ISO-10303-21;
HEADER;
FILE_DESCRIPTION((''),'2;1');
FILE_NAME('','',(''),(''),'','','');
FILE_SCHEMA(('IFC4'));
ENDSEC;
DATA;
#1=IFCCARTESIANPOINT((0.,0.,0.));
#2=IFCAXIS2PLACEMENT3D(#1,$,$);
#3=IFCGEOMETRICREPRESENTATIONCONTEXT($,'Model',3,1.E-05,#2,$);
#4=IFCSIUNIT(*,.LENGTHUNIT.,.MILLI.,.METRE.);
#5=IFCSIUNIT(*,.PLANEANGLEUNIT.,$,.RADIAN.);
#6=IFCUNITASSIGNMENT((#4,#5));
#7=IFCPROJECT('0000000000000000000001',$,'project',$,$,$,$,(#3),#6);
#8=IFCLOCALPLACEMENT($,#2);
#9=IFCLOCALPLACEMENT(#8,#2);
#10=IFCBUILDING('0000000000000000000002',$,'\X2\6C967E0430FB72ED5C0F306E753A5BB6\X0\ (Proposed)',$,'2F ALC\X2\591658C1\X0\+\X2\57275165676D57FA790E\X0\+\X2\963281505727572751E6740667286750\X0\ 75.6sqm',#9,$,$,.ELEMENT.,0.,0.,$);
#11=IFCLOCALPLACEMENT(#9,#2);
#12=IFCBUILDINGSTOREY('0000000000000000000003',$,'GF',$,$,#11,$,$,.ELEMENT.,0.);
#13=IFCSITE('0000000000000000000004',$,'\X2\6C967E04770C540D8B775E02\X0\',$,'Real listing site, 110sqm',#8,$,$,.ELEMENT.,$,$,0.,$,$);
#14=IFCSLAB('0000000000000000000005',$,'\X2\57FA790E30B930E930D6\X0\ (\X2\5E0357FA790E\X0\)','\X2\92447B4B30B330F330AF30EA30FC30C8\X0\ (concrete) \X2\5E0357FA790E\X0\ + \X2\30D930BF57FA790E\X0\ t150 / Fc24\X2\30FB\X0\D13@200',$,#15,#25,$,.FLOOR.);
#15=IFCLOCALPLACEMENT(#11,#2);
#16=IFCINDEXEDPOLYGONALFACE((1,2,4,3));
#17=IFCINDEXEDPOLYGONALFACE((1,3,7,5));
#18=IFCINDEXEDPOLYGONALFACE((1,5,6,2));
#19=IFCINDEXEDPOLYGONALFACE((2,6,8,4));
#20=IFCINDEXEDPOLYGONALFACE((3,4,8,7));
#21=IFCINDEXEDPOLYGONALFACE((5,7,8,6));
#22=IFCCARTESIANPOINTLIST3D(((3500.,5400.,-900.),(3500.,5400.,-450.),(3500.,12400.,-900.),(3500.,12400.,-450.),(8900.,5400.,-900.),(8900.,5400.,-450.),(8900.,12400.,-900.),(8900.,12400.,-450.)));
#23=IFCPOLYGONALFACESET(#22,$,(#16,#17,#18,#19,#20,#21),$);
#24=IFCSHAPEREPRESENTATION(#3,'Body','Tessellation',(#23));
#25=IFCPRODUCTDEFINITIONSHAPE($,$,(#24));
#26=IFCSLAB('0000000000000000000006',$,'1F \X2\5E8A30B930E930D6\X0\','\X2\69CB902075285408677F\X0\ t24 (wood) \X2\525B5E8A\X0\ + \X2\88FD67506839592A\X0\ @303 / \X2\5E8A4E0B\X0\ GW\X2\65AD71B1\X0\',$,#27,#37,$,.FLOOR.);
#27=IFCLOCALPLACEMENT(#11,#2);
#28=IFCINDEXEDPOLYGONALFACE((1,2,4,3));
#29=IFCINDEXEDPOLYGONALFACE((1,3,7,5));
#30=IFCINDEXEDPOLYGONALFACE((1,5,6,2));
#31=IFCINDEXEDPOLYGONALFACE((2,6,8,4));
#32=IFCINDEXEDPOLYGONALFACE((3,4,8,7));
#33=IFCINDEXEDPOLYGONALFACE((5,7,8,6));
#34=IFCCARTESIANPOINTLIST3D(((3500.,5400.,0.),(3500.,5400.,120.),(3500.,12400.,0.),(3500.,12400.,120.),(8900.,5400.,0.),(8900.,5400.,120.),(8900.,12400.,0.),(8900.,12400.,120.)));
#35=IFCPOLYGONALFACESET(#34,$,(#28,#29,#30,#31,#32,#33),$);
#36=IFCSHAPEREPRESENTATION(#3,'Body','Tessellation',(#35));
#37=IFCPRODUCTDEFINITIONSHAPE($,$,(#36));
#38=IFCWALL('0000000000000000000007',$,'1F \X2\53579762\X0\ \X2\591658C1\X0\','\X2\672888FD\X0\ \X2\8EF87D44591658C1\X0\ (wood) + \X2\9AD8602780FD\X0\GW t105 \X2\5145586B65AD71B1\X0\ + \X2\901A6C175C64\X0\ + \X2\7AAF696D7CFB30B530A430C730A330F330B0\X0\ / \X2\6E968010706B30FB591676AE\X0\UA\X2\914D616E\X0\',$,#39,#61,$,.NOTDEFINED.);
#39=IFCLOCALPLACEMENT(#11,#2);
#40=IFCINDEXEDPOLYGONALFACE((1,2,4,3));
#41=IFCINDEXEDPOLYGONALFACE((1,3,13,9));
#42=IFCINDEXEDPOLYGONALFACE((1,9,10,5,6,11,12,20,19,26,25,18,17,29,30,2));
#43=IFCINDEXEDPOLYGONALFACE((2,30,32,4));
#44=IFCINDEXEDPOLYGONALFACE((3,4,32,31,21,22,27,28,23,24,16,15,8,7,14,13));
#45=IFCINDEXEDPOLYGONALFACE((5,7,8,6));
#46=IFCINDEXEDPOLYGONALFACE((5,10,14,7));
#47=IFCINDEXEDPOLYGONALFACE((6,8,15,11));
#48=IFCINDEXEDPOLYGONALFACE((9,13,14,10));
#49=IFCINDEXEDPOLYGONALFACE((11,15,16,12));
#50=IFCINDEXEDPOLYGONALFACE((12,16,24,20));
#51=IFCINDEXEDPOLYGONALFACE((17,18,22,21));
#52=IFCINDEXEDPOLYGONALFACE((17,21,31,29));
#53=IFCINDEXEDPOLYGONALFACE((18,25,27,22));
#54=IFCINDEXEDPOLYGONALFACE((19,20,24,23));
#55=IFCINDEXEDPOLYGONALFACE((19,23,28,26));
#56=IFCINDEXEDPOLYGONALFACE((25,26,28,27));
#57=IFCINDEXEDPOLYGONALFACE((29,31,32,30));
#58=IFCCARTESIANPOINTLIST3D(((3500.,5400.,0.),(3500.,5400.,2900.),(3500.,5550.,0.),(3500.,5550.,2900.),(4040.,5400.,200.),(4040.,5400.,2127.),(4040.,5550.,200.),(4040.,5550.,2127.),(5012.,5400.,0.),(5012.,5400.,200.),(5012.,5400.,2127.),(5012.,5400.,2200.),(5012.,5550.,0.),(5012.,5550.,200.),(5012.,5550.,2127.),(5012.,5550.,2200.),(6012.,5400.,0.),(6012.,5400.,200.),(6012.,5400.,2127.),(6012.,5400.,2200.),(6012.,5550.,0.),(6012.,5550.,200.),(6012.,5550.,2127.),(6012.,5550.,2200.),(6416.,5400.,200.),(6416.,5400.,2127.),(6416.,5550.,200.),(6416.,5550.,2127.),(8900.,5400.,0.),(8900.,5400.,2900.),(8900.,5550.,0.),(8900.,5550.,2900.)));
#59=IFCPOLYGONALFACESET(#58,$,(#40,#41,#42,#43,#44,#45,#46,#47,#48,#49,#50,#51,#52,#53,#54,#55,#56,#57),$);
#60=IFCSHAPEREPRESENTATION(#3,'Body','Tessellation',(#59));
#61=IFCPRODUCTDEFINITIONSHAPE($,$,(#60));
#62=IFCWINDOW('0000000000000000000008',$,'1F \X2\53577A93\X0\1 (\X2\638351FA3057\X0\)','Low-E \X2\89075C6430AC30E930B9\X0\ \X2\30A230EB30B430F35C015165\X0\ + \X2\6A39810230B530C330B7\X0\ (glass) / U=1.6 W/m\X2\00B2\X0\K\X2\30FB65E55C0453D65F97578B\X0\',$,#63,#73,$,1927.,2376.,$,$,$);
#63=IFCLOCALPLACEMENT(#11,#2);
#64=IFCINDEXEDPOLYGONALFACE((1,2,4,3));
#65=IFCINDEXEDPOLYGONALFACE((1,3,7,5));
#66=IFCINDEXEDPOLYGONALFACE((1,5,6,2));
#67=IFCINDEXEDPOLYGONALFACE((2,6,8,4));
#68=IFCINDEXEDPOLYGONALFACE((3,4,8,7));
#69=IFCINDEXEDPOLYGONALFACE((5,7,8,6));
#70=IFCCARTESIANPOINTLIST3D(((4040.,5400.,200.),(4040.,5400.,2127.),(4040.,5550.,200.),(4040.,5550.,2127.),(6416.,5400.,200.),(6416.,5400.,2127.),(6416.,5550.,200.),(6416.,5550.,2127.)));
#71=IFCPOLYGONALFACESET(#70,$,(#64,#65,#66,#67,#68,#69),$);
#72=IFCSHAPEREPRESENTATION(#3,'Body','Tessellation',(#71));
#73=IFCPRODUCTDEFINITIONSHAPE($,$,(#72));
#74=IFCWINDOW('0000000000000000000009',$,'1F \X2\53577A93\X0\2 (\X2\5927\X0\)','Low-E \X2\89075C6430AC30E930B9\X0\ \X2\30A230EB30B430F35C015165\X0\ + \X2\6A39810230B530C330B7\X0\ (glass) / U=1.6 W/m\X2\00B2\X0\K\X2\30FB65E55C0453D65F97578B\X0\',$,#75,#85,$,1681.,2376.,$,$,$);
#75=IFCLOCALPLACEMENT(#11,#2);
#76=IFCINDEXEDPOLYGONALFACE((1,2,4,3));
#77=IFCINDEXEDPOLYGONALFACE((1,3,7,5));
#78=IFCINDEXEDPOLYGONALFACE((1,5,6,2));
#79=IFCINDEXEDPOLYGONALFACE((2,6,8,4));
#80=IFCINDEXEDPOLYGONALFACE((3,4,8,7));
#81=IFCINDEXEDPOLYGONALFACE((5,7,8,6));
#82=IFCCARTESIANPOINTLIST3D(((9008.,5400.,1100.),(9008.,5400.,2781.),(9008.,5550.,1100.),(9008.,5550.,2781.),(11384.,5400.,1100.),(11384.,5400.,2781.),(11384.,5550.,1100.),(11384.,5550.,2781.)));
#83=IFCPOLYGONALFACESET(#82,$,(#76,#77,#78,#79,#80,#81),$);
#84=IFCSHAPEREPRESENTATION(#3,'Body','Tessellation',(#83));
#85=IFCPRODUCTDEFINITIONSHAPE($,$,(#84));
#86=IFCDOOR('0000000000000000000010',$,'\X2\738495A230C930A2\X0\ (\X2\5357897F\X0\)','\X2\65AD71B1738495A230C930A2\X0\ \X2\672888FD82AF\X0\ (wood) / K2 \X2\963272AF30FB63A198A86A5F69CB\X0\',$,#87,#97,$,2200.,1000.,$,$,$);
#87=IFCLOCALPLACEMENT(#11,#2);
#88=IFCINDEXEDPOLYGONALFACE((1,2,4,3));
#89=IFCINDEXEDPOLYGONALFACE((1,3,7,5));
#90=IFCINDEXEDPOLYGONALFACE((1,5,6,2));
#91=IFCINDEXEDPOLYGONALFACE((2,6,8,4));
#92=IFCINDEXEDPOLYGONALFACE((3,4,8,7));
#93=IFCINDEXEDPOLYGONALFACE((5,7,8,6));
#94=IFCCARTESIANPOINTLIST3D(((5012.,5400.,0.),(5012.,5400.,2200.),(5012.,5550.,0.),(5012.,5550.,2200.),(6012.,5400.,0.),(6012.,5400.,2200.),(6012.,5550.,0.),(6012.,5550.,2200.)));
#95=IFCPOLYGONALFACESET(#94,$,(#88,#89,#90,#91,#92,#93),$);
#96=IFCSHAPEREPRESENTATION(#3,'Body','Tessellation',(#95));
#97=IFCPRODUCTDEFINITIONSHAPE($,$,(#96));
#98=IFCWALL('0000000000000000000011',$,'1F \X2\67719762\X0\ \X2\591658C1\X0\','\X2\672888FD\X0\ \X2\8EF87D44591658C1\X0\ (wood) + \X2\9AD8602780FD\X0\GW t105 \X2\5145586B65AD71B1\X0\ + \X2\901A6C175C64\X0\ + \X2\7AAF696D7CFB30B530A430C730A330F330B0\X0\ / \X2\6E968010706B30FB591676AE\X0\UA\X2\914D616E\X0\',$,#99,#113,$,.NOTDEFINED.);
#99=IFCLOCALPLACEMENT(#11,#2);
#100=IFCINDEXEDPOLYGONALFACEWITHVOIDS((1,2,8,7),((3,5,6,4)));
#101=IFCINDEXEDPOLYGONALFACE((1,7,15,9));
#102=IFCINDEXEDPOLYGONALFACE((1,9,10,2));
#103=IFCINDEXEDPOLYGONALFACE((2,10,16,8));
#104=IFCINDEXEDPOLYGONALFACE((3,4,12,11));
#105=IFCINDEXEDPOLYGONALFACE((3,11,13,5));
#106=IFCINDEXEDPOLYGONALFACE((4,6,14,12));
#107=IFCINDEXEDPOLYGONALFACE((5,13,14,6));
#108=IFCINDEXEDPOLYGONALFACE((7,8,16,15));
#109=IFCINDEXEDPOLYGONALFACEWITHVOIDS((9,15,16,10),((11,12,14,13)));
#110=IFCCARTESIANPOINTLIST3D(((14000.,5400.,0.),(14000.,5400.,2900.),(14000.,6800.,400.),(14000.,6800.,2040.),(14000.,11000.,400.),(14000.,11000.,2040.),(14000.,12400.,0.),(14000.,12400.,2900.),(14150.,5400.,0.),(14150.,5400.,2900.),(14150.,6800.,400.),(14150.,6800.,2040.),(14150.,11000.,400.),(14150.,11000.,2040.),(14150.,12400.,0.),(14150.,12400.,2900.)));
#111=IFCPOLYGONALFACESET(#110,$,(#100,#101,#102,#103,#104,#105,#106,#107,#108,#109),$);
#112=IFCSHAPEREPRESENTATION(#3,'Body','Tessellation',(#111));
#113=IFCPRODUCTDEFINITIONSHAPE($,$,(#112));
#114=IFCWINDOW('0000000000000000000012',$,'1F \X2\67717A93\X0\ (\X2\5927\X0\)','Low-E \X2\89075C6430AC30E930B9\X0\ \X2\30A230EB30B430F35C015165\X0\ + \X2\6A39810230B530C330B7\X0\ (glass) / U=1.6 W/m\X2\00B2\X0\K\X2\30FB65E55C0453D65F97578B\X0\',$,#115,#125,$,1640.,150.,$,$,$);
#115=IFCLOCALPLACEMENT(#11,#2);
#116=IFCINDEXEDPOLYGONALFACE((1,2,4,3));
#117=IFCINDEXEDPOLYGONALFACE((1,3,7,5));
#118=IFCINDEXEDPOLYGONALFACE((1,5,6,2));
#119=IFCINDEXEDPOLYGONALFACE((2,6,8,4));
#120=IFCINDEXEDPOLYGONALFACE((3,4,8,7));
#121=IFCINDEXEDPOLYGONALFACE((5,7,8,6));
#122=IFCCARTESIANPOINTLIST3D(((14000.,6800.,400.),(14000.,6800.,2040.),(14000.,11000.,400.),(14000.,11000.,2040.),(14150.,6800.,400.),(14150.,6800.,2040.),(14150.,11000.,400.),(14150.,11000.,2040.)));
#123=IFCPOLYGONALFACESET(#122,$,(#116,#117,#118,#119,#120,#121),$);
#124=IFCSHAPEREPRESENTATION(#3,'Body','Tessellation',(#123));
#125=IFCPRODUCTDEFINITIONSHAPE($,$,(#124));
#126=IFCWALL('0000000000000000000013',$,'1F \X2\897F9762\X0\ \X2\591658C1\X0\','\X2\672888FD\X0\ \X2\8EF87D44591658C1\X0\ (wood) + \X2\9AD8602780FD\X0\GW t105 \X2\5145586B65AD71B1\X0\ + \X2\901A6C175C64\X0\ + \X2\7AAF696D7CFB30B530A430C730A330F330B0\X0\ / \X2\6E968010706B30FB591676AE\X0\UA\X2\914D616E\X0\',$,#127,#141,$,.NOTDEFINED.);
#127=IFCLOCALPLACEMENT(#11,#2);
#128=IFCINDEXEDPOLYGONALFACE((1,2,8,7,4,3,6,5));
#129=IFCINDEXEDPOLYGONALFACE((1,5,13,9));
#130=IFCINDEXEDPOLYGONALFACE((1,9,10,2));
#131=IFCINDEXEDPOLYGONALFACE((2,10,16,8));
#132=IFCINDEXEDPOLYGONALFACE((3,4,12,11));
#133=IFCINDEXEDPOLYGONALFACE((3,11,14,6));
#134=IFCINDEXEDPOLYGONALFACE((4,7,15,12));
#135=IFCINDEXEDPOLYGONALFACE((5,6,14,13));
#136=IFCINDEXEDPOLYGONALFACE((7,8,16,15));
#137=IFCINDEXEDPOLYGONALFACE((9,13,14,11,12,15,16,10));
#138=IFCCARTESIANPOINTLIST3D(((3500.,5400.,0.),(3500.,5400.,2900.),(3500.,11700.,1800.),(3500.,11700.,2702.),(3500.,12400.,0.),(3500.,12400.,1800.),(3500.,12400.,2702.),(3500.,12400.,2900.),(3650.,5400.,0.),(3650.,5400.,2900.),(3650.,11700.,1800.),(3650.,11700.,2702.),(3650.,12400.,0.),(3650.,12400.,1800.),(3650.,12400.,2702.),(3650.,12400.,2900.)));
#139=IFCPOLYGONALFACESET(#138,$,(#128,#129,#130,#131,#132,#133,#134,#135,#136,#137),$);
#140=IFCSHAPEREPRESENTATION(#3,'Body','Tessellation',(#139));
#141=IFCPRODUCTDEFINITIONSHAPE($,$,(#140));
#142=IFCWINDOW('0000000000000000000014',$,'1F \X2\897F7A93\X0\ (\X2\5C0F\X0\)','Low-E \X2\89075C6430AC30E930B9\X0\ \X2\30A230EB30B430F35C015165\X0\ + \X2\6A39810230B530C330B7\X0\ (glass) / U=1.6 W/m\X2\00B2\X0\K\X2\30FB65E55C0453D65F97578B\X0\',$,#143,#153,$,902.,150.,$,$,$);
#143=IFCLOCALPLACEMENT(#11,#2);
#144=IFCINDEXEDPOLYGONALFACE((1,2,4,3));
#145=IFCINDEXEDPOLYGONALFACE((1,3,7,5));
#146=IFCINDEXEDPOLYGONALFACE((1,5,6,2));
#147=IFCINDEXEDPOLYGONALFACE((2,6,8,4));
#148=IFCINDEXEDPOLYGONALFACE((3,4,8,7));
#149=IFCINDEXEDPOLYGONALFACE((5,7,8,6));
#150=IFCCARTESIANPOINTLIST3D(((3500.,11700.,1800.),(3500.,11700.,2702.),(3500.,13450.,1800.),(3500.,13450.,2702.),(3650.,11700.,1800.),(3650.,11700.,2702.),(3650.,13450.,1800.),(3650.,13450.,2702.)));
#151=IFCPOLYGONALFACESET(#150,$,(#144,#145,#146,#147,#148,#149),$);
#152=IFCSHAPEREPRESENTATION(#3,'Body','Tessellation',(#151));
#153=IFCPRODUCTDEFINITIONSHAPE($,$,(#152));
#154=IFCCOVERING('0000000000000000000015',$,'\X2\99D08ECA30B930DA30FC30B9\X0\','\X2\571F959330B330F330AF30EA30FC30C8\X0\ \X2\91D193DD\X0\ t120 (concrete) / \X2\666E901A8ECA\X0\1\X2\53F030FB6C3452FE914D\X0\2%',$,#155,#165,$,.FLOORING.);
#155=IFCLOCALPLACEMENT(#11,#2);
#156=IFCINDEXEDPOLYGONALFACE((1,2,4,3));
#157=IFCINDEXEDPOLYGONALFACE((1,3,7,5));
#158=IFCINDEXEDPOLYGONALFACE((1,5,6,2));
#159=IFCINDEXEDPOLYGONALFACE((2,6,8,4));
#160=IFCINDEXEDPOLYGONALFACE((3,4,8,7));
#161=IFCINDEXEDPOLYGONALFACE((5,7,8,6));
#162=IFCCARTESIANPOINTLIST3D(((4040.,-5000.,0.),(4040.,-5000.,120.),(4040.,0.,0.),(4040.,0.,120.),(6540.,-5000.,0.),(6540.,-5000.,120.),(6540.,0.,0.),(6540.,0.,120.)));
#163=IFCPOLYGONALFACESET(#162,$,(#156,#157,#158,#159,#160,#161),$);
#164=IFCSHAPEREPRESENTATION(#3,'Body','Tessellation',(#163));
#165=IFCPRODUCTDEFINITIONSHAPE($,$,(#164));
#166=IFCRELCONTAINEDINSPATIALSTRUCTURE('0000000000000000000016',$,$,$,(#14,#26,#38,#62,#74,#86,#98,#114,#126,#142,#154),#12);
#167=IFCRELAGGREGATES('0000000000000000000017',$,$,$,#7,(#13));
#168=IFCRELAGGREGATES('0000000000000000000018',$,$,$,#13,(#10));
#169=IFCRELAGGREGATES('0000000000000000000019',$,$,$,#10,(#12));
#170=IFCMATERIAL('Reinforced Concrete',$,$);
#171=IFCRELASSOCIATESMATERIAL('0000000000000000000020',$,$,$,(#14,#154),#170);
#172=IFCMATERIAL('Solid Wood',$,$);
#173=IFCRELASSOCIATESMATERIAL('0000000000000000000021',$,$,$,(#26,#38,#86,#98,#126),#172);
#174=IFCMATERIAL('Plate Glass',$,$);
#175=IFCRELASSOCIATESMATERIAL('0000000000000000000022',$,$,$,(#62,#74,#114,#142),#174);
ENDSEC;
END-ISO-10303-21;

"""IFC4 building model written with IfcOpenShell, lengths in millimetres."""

from ifc_helpers import new_model, si_unit, frame, frame_2d, origin, place, context, project, spatial, rectangle, extrude, material, element, fill, save


model = new_model("IFC4")

# Units and contexts
model_context = context("Model", 3, precision=1e-05, world=origin())
ifc_project = project(units=[si_unit("LENGTHUNIT", "METRE", prefix="MILLI"), si_unit("PLANEANGLEUNIT", "RADIAN")], contexts=[model_context])

# Site, building, storey
site_placement = place(None, origin())
site = spatial("IfcSite", under=ifc_project, at=site_placement, Name="沖縄県名護市", ObjectType="Real listing site, 110sqm", CompositionType="ELEMENT", RefElevation=0.0)
building_placement = place(site_placement, origin())
building = spatial("IfcBuilding", under=site, at=building_placement, Name="沖縄・狭小の町家 (Proposed)", ObjectType="2F ALC外壁+圧入杭基礎+防腐圧圧処理木材 75.6sqm", CompositionType="ELEMENT", ElevationOfRefHeight=0.0, ElevationOfTerrain=0.0)
storey_placement = place(building_placement, origin())
storey = spatial("IfcBuildingStorey", under=building, at=storey_placement, Name="GF", CompositionType="ELEMENT", Elevation=0.0)

# Shared definitions
ifc_material_1 = material(Name="Solid Wood")

# Slabs
ifc_material_2 = material(Name="Reinforced Concrete")
slab_1_placement = place(storey_placement, frame((1750.0, 2700.0, -450.0)))
element("IfcSlab", 1, at=slab_1_placement, inside=storey, material=ifc_material_2, Name="基礎スラブ (布基礎)", Description="鉄筋コンクリート (concrete) 布基礎 + ベタ基礎 t150 / Fc24・D13@200", PredefinedType="FLOOR", context=model_context, shape_type="SweptSolid", body=[
    extrude(rectangle(XDim=5400.0, YDim=7000.0, at=frame_2d((2700.0, 3500.0))), frame((1750.0, 2700.0, -450.0)), (0.0, 0.0, 1.0), 450.0),
])
slab_2_placement = place(storey_placement, frame((1750.0, 2700.0, 0.0)))
element("IfcSlab", 2, at=slab_2_placement, inside=storey, material=ifc_material_1, Name="1F 床スラブ", Description="構造用合板 t24 (wood) 剛床 + 製材根太 @303 / 床下 GW断熱", PredefinedType="FLOOR", context=model_context, shape_type="SweptSolid", body=[
    extrude(rectangle(XDim=5400.0, YDim=7000.0, at=frame_2d((2700.0, 3500.0))), frame((1750.0, 2700.0, 0.0)), (0.0, 0.0, 1.0), 120.0),
])

# Wall, openings, windows, door
wall_1_placement = place(storey_placement, frame((1750.0, 2700.0, 0.0)))
wall_1 = element("IfcWall", 3, at=wall_1_placement, inside=storey, material=ifc_material_1, Name="1F 南面 外壁", Description="木製 軸組外壁 (wood) + 高性能GW t105 充填断熱 + 通気層 + 窯業系サイディング / 準耐火・外皮UA配慮", PredefinedType="NOTDEFINED", context=model_context, shape_type="SweptSolid", body=[
    extrude(rectangle(XDim=5400.0, YDim=150.0, at=frame_2d((2700.0, 75.0))), frame((1750.0, 2700.0, 0.0)), (0.0, 0.0, 1.0), 2900.0),
])
opening_1_placement = place(storey_placement, frame((2020.0, 2700.0, 100.0)))
opening_1 = element("IfcOpeningElement", 4, at=opening_1_placement, cuts=wall_1, PredefinedType="NOTDEFINED", context=model_context, shape_type="SweptSolid", body=[
    extrude(rectangle(XDim=2376.0, YDim=150.0, at=frame_2d((1188.0, 75.0))), frame((2020.0, 2700.0, 100.0)), (0.0, 0.0, 1.0), 1927.0),
])
opening_2_placement = place(storey_placement, frame((4504.0, 2700.0, 550.0)))
opening_2 = element("IfcOpeningElement", 5, at=opening_2_placement, cuts=wall_1, PredefinedType="NOTDEFINED", context=model_context, shape_type="SweptSolid", body=[
    extrude(rectangle(XDim=2376.0, YDim=150.0, at=frame_2d((1188.0, 75.0))), frame((4504.0, 2700.0, 550.0)), (0.0, 0.0, 1.0), 1681.0),
])
opening_3_placement = place(storey_placement, frame((2506.0, 2700.0, 0.0)))
opening_3 = element("IfcOpeningElement", 6, at=opening_3_placement, cuts=wall_1, PredefinedType="NOTDEFINED", context=model_context, shape_type="SweptSolid", body=[
    extrude(rectangle(XDim=1000.0, YDim=150.0, at=frame_2d((500.0, 75.0))), frame((2506.0, 2700.0, 0.0)), (0.0, 0.0, 1.0), 2200.0),
])
ifc_material_3 = material(Name="Plate Glass")
window_1_placement = place(storey_placement, frame((2020.0, 2700.0, 100.0)))
window_1 = element("IfcWindow", 7, at=window_1_placement, inside=storey, material=ifc_material_3, Name="1F 南窓1 (掃出し)", Description="Low-E 複層ガラス アルゴン封入 + 樹脂サッシ (glass) / U=1.6 W/m²K・日射取得型", OverallHeight=1927.0, OverallWidth=2376.0, context=model_context, shape_type="SweptSolid", body=[
    extrude(rectangle(XDim=2376.0, YDim=150.0, at=frame_2d((1188.0, 75.0))), frame((2020.0, 2700.0, 100.0)), (0.0, 0.0, 1.0), 1927.0),
])
fill(opening_1, window_1)
window_2_placement = place(storey_placement, frame((4504.0, 2700.0, 550.0)))
window_2 = element("IfcWindow", 8, at=window_2_placement, inside=storey, material=ifc_material_3, Name="1F 南窓2 (大)", Description="Low-E 複層ガラス アルゴン封入 + 樹脂サッシ (glass) / U=1.6 W/m²K・日射取得型", OverallHeight=1681.0, OverallWidth=2376.0, context=model_context, shape_type="SweptSolid", body=[
    extrude(rectangle(XDim=2376.0, YDim=150.0, at=frame_2d((1188.0, 75.0))), frame((4504.0, 2700.0, 550.0)), (0.0, 0.0, 1.0), 1681.0),
])
fill(opening_2, window_2)
door_placement = place(storey_placement, frame((2506.0, 2700.0, 0.0)))
door = element("IfcDoor", 9, at=door_placement, inside=storey, material=ifc_material_1, Name="玄関ドア (南西)", Description="断熱玄関ドア 木製芯 (wood) / K2 防犯・採風機構", OverallHeight=2200.0, OverallWidth=1000.0, context=model_context, shape_type="SweptSolid", body=[
    extrude(rectangle(XDim=1000.0, YDim=150.0, at=frame_2d((500.0, 75.0))), frame((2506.0, 2700.0, 0.0)), (0.0, 0.0, 1.0), 2200.0),
])
fill(opening_3, door)

# Walls, openings, windows
wall_2_placement = place(storey_placement, frame((7000.0, 2700.0, 0.0)))
wall_2 = element("IfcWall", 10, at=wall_2_placement, inside=storey, material=ifc_material_1, Name="1F 東面 外壁", Description="木製 軸組外壁 (wood) + 高性能GW t105 充填断熱 + 通気層 + 窯業系サイディング / 準耐火・外皮UA配慮", PredefinedType="NOTDEFINED", context=model_context, shape_type="SweptSolid", body=[
    extrude(rectangle(XDim=150.0, YDim=7000.0, at=frame_2d((75.0, 3500.0))), frame((7000.0, 2700.0, 0.0)), (0.0, 0.0, 1.0), 2900.0),
])
opening_4_placement = place(storey_placement, frame((7000.0, 3400.0, 200.0)))
opening_4 = element("IfcOpeningElement", 11, at=opening_4_placement, cuts=wall_2, PredefinedType="NOTDEFINED", context=model_context, shape_type="SweptSolid", body=[
    extrude(rectangle(XDim=150.0, YDim=4200.0, at=frame_2d((75.0, 2100.0))), frame((7000.0, 3400.0, 200.0)), (0.0, 0.0, 1.0), 1640.0),
])
window_3_placement = place(storey_placement, frame((7000.0, 3400.0, 200.0)))
window_3 = element("IfcWindow", 12, at=window_3_placement, inside=storey, material=ifc_material_3, Name="1F 東窓 (大)", Description="Low-E 複層ガラス アルゴン封入 + 樹脂サッシ (glass) / U=1.6 W/m²K・日射取得型", OverallHeight=1640.0, OverallWidth=150.0, context=model_context, shape_type="SweptSolid", body=[
    extrude(rectangle(XDim=150.0, YDim=4200.0, at=frame_2d((75.0, 2100.0))), frame((7000.0, 3400.0, 200.0)), (0.0, 0.0, 1.0), 1640.0),
])
fill(opening_4, window_3)
wall_3_placement = place(storey_placement, frame((1750.0, 2700.0, 0.0)))
wall_3 = element("IfcWall", 13, at=wall_3_placement, inside=storey, material=ifc_material_1, Name="1F 西面 外壁", Description="木製 軸組外壁 (wood) + 高性能GW t105 充填断熱 + 通気層 + 窯業系サイディング / 準耐火・外皮UA配慮", PredefinedType="NOTDEFINED", context=model_context, shape_type="SweptSolid", body=[
    extrude(rectangle(XDim=150.0, YDim=7000.0, at=frame_2d((75.0, 3500.0))), frame((1750.0, 2700.0, 0.0)), (0.0, 0.0, 1.0), 2900.0),
])
opening_5_placement = place(storey_placement, frame((1750.0, 5850.0, 900.0)))
opening_5 = element("IfcOpeningElement", 14, at=opening_5_placement, cuts=wall_3, PredefinedType="NOTDEFINED", context=model_context, shape_type="SweptSolid", body=[
    extrude(rectangle(XDim=150.0, YDim=1750.0, at=frame_2d((75.0, 875.0))), frame((1750.0, 5850.0, 900.0)), (0.0, 0.0, 1.0), 902.0),
])
window_4_placement = place(storey_placement, frame((1750.0, 5850.0, 900.0)))
window_4 = element("IfcWindow", 15, at=window_4_placement, inside=storey, material=ifc_material_3, Name="1F 西窓 (小)", Description="Low-E 複層ガラス アルゴン封入 + 樹脂サッシ (glass) / U=1.6 W/m²K・日射取得型", OverallHeight=902.0, OverallWidth=150.0, context=model_context, shape_type="SweptSolid", body=[
    extrude(rectangle(XDim=150.0, YDim=1750.0, at=frame_2d((75.0, 875.0))), frame((1750.0, 5850.0, 900.0)), (0.0, 0.0, 1.0), 902.0),
])
fill(opening_5, window_4)

# Covering
covering_1_placement = place(storey_placement, frame((2020.0, -2500.0, 0.0)))
element("IfcCovering", 16, at=covering_1_placement, inside=storey, material=ifc_material_2, Name="駐車スペース", Description="土間コンクリート 金鏝 t120 (concrete) / 普通車1台・水勾配2%", PredefinedType="FLOORING", context=model_context, shape_type="SweptSolid", body=[
    extrude(rectangle(XDim=2500.0, YDim=5000.0, at=frame_2d((1250.0, 2500.0))), frame((2020.0, -2500.0, 0.0)), (0.0, 0.0, 1.0), 120.0),
])

save(model, "model.ifc")
